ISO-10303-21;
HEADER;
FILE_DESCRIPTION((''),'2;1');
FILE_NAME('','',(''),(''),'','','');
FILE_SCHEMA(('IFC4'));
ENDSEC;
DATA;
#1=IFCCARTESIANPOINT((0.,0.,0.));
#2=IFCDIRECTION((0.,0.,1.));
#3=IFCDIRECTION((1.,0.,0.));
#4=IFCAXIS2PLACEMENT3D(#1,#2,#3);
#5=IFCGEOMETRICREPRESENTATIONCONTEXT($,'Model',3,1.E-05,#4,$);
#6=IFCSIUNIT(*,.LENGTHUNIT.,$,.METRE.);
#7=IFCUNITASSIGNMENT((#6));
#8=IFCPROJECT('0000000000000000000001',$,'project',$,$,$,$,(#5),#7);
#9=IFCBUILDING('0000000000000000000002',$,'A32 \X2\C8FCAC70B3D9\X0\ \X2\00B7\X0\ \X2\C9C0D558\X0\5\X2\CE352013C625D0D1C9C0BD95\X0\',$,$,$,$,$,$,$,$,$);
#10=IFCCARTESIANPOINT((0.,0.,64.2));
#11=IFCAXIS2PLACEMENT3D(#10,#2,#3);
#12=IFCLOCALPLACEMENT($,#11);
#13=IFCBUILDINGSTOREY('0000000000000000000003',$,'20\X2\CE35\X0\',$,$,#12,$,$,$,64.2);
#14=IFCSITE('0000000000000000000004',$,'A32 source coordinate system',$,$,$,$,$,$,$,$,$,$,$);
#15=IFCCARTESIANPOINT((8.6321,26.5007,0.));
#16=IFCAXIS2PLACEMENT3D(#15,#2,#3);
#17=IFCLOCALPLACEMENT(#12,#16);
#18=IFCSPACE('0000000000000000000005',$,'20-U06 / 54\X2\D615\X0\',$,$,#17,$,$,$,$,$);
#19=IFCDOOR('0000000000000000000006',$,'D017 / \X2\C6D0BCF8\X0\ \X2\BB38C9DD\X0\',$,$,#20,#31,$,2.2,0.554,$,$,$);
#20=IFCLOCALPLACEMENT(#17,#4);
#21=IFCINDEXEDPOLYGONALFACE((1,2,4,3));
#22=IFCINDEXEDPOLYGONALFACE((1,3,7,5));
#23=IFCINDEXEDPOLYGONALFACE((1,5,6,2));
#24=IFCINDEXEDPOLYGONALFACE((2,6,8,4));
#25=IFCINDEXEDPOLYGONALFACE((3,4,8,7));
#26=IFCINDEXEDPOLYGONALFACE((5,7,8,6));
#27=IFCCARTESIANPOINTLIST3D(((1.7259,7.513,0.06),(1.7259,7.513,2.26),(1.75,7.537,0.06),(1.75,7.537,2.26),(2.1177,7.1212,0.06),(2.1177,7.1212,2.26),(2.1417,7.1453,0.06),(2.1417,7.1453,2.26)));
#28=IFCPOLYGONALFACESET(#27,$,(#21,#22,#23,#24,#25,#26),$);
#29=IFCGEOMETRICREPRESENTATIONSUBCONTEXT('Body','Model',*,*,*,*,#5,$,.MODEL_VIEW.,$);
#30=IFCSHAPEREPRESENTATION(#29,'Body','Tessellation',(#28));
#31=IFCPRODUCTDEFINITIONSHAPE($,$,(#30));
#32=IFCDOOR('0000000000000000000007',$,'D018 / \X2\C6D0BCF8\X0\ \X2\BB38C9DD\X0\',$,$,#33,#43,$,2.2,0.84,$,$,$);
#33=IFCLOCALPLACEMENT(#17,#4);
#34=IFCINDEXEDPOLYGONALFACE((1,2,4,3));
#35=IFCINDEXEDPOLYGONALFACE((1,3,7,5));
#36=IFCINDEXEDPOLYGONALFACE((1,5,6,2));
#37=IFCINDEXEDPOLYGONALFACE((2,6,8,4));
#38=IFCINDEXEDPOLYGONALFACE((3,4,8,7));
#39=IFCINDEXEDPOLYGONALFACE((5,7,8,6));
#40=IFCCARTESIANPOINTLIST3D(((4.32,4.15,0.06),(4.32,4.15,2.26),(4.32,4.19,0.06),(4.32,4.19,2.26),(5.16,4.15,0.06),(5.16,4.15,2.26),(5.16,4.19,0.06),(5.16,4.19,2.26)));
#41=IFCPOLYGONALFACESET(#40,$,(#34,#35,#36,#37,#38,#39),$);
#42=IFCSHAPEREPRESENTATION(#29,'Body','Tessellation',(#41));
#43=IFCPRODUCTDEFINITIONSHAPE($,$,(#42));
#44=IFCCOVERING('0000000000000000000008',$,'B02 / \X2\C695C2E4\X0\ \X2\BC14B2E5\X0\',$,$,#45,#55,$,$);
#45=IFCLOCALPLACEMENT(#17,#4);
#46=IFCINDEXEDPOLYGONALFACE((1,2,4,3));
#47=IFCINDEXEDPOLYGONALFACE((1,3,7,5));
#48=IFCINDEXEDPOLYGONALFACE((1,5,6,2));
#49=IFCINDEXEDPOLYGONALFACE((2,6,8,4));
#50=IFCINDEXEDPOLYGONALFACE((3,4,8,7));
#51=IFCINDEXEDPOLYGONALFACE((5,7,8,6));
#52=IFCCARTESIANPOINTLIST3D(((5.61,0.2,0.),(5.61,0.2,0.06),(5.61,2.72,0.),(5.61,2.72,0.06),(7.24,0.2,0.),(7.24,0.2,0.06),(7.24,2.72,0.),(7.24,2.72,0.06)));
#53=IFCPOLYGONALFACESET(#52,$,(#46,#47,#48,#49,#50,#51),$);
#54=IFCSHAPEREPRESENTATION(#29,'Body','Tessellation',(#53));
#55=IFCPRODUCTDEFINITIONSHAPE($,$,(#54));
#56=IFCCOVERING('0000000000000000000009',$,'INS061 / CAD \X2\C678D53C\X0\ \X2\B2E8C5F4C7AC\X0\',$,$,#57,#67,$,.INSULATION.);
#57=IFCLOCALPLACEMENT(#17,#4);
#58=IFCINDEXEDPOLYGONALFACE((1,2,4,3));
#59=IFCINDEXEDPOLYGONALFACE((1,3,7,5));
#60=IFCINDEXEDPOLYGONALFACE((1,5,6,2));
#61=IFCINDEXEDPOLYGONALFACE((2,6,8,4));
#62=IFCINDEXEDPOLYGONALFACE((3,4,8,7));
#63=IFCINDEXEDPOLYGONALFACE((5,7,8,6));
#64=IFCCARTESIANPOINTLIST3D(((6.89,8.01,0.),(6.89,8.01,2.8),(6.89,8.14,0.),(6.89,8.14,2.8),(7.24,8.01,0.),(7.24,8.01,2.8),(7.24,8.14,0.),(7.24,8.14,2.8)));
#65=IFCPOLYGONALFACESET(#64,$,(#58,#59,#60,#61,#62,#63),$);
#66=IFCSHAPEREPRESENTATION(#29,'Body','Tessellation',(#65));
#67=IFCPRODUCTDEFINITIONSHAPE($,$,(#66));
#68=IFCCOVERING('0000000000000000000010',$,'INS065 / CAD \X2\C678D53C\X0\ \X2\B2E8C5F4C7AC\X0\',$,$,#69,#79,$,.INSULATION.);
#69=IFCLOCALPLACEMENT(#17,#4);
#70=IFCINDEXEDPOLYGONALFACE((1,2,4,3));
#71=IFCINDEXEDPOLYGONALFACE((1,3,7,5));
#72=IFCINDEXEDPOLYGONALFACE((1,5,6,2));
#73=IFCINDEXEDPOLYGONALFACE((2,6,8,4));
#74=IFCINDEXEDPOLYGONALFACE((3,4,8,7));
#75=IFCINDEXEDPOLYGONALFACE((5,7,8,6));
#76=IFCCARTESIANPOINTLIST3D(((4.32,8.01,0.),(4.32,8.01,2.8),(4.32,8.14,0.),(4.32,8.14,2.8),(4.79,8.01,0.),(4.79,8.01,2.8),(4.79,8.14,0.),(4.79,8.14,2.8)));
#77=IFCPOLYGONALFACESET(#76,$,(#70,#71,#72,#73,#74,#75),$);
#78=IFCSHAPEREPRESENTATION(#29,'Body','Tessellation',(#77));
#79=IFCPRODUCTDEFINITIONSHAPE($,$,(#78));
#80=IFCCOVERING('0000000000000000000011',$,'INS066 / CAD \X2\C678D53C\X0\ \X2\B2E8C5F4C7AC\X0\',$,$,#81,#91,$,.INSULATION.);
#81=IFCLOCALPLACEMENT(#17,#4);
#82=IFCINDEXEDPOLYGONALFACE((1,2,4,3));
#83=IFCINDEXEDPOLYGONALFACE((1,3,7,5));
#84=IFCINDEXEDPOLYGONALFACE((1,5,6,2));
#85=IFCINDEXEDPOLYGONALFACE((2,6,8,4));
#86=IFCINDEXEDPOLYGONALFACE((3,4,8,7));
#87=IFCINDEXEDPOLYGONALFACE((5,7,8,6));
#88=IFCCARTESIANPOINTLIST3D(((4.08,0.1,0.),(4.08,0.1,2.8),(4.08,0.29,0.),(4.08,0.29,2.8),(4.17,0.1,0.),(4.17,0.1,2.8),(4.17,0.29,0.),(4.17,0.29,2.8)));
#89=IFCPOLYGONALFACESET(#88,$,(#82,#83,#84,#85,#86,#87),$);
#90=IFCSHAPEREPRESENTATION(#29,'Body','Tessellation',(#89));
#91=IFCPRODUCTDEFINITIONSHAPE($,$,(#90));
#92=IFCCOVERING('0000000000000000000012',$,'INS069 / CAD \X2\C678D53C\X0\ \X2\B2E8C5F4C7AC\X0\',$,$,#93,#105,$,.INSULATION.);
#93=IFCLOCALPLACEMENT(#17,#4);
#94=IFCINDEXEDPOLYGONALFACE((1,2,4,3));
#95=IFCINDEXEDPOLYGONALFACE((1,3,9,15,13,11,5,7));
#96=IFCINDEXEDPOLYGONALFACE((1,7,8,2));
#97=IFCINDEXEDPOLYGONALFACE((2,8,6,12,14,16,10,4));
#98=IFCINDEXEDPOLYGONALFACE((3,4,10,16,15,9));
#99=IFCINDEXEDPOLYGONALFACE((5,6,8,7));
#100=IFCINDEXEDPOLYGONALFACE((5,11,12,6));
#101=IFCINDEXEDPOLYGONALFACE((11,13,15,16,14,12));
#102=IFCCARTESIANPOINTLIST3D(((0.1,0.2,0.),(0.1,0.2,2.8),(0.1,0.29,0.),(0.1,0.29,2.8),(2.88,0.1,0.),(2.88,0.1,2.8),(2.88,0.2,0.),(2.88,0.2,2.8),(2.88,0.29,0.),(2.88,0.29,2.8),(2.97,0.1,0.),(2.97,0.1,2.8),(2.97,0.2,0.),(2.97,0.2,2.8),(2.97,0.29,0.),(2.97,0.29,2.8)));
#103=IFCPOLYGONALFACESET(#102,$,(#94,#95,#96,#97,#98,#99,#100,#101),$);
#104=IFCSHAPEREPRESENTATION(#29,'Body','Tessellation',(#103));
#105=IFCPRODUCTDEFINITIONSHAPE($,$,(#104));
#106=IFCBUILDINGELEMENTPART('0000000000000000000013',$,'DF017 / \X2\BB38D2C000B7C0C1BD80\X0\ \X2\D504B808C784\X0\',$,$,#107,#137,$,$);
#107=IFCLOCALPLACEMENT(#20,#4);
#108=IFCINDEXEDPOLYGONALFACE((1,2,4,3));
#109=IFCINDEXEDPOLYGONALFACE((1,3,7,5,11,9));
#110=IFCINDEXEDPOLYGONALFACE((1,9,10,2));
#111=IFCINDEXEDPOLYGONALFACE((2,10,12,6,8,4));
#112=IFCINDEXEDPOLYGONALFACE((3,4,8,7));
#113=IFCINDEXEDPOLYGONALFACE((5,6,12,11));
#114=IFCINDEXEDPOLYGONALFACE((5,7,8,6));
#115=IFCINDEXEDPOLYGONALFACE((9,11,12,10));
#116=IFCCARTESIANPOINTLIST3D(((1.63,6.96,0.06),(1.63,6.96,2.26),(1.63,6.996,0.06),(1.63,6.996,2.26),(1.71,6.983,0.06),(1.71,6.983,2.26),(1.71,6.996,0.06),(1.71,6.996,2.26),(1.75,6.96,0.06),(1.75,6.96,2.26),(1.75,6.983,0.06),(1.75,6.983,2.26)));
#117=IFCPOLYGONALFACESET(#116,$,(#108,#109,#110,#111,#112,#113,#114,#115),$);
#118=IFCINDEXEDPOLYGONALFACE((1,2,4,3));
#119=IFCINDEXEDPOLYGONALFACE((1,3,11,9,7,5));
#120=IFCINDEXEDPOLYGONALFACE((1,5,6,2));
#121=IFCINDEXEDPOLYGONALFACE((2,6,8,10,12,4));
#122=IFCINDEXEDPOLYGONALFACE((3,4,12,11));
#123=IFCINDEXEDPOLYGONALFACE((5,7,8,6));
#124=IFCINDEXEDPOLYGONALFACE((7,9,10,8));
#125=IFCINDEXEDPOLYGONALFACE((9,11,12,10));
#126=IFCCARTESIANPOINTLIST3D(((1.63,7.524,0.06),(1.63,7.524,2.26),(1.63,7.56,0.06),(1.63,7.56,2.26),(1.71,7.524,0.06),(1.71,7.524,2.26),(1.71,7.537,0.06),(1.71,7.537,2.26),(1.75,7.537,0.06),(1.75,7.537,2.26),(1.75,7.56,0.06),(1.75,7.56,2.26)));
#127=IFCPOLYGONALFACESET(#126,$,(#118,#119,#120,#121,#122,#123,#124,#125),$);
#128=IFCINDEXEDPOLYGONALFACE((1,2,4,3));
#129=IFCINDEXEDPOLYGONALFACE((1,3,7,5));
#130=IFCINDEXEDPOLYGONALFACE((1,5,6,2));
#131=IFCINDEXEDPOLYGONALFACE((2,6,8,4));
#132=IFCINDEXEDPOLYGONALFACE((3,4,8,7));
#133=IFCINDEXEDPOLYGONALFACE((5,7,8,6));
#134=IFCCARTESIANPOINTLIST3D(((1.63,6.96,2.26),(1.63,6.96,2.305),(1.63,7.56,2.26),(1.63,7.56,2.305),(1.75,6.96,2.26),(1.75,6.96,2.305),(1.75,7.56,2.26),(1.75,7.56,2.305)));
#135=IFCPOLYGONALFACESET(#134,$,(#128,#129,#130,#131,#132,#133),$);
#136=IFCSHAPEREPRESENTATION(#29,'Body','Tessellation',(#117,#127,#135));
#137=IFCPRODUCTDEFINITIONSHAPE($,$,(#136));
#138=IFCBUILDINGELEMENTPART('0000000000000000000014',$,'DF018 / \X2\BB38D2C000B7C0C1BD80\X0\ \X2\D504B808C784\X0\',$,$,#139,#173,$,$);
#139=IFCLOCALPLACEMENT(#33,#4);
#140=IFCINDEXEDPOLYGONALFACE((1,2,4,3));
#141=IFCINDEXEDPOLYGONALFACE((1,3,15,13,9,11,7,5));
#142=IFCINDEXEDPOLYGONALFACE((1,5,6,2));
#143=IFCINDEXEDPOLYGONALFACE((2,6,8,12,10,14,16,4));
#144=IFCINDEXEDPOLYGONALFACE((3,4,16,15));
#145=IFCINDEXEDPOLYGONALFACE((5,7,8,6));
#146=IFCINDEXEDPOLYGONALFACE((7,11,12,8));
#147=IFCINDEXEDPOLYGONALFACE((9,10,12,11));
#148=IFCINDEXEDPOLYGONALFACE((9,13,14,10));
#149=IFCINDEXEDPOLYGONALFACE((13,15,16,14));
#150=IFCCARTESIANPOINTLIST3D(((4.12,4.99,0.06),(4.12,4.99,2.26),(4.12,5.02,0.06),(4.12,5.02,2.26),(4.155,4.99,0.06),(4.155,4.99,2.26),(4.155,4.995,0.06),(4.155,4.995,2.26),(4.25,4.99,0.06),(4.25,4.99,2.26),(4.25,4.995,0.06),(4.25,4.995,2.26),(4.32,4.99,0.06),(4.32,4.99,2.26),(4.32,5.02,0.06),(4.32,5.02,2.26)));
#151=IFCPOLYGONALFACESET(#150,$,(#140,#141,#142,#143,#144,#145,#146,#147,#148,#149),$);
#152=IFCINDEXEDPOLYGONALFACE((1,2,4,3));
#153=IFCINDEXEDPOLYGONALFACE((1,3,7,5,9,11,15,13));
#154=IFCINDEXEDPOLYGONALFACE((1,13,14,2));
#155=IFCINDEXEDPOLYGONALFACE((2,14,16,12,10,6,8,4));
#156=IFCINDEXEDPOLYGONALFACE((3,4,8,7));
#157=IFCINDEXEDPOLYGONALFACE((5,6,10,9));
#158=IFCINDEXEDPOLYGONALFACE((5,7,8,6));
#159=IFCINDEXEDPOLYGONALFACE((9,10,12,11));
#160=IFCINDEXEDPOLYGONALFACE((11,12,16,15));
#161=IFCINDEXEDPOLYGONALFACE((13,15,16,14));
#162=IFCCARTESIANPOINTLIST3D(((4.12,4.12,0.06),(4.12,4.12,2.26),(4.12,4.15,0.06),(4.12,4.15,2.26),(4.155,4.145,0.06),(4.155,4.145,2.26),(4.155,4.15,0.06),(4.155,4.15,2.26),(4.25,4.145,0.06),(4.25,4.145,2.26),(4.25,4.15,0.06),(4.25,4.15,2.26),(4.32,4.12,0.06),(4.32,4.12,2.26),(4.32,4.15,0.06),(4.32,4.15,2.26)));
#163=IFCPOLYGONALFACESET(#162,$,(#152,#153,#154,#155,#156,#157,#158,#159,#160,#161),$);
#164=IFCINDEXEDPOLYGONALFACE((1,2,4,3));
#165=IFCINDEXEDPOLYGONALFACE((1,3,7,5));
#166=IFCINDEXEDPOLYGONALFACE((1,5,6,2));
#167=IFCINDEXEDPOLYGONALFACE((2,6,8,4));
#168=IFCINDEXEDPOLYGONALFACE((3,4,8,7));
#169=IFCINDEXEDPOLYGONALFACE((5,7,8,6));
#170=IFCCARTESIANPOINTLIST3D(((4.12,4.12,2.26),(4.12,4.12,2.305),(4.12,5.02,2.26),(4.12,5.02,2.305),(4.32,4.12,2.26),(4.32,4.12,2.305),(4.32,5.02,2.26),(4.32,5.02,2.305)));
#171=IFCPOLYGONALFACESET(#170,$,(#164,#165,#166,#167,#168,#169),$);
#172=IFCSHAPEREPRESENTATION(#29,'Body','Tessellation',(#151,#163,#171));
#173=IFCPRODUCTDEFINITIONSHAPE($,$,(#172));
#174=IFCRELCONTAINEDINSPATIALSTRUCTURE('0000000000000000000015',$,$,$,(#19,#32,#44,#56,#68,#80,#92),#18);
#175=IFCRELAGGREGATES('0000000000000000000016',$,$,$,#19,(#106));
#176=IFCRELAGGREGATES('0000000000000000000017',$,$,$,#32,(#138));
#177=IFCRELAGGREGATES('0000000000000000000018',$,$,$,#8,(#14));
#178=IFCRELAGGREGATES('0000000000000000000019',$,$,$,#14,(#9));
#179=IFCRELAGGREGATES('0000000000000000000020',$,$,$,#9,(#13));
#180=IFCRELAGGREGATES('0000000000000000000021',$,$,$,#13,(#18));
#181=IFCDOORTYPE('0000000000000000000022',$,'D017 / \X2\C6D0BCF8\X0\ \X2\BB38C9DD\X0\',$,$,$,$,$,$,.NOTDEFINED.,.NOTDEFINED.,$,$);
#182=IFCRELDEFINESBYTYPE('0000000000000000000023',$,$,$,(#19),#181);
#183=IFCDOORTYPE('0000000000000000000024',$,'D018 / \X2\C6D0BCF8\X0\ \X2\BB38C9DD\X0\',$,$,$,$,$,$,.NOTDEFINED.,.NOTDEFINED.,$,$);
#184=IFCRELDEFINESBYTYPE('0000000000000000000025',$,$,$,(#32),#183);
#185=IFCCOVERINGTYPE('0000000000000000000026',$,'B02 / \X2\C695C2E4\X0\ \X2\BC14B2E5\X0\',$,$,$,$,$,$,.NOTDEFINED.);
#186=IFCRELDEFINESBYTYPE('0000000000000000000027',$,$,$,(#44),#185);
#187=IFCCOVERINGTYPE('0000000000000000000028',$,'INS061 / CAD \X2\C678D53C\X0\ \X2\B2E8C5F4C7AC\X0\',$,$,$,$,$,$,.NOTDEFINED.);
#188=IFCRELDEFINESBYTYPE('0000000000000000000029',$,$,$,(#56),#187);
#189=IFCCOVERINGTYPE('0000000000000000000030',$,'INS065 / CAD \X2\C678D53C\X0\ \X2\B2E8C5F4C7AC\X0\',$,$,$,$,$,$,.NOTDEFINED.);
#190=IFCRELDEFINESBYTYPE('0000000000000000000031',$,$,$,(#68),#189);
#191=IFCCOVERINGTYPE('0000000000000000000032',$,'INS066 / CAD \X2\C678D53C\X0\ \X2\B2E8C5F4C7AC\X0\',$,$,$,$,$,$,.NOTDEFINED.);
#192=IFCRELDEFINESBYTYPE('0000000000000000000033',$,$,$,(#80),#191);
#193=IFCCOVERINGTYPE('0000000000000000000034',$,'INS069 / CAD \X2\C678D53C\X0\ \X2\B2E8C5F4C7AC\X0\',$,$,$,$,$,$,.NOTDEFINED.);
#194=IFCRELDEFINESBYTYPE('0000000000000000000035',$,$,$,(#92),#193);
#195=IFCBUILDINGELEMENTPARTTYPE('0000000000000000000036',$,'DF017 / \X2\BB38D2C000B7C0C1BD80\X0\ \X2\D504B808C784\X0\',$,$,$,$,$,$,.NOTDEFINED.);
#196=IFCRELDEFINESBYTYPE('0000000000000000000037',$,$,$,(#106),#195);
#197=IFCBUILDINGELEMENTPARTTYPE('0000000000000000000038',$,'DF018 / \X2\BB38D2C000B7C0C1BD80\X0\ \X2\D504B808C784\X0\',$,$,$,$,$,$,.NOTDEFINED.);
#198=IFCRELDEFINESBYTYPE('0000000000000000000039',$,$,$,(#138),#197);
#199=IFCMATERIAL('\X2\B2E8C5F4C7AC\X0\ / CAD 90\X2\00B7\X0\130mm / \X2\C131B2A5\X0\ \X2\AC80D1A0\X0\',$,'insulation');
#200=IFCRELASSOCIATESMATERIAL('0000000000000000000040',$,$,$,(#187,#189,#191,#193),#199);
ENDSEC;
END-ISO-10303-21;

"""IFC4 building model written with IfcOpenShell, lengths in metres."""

from ifc_helpers import new_model, si_unit, frame, origin, origin_with_axes, place, context, subcontext, project, spatial, polyline, outline, extrude, source, transform, mapped, material, type_object, type_shapes, element, aggregate, save


model = new_model("IFC4")

# Units and contexts
model_context = context("Model", 3, precision=1e-05, world=origin_with_axes())
body_context = subcontext(model_context, "Body", "Model", "MODEL_VIEW")
ifc_project = project(units=[si_unit("LENGTHUNIT", "METRE")], contexts=[model_context])

# Site, building, storey, space
storey_placement = place(None, frame((0.0, 0.0, 64.2), z_axis=(0.0, 0.0, 1.0), x_axis=(1.0, 0.0, 0.0)))
space_1_placement = place(storey_placement, frame((8.6321, 26.5007, 0.0), z_axis=(0.0, 0.0, 1.0), x_axis=(1.0, 0.0, 0.0)))
site = spatial("IfcSite", under=ifc_project, Name="A32 source coordinate system")
building = spatial("IfcBuilding", under=site, Name="A32 주거동 · 지하5층–옥탑지붕")
storey = spatial("IfcBuildingStorey", under=building, at=storey_placement, Name="20층", Elevation=64.2)
space_1 = spatial("IfcSpace", under=storey, at=space_1_placement, Name="20-U06 / 54형")

# Doors
door_type_1 = type_object("IfcDoorType", Name="D017 / 원본 문짝", OperationType="NOTDEFINED", PredefinedType="NOTDEFINED")
shared_shape_1 = source(origin(), body_context, "Body", "SweptSolid", [
    extrude(outline(polyline([(1.75, 7.537), (2.1417, 7.1453), (2.1177, 7.1212), (1.7259, 7.513), (1.75, 7.537)])), frame((0.0, 0.0, 0.06)), (0.0, 0.0, 1.0), 2.2),
])
type_shapes(door_type_1, [shared_shape_1])
door_1_placement = place(space_1_placement, origin_with_axes())
door_1 = element("IfcDoor", 1, at=door_1_placement, inside=space_1, type_object=door_type_1, Name="D017 / 원본 문짝", OverallHeight=2.2, OverallWidth=0.554, context=body_context, shape_type="MappedRepresentation", body=[
    mapped(shared_shape_1, transform((0.0, 0.0, 0.0), scale=1.0)),
])
door_type_2 = type_object("IfcDoorType", Name="D018 / 원본 문짝", OperationType="NOTDEFINED", PredefinedType="NOTDEFINED")
shared_shape_2 = source(origin(), body_context, "Body", "SweptSolid", [
    extrude(outline(polyline([(5.16, 4.19), (5.16, 4.15), (4.32, 4.15), (4.32, 4.19), (5.16, 4.19)])), frame((0.0, 0.0, 0.06)), (0.0, 0.0, 1.0), 2.2),
])
type_shapes(door_type_2, [shared_shape_2])
door_2_placement = place(space_1_placement, origin_with_axes())
door_2 = element("IfcDoor", 2, at=door_2_placement, inside=space_1, type_object=door_type_2, Name="D018 / 원본 문짝", OverallHeight=2.2, OverallWidth=0.84, context=body_context, shape_type="MappedRepresentation", body=[
    mapped(shared_shape_2, transform((0.0, 0.0, 0.0), scale=1.0)),
])

# Coverings
covering_type_1 = type_object("IfcCoveringType", Name="B02 / 욕실 바닥", PredefinedType="NOTDEFINED")
shared_shape_3 = source(origin(), body_context, "Body", "SweptSolid", [
    extrude(outline(polyline([(5.61, 2.72), (7.24, 2.72), (7.24, 0.2), (5.61, 0.2), (5.61, 2.72)])), origin(), (0.0, 0.0, 1.0), 0.06),
])
type_shapes(covering_type_1, [shared_shape_3])
covering_1_placement = place(space_1_placement, origin_with_axes())
element("IfcCovering", 3, at=covering_1_placement, inside=space_1, type_object=covering_type_1, Name="B02 / 욕실 바닥", context=body_context, shape_type="MappedRepresentation", body=[
    mapped(shared_shape_3, transform((0.0, 0.0, 0.0), scale=1.0)),
])
ifc_material = material(Name="단열재 / CAD 90·130mm / 성능 검토", Category="insulation")
covering_type_2 = type_object("IfcCoveringType", Name="INS061 / CAD 외피 단열재", PredefinedType="NOTDEFINED", material=ifc_material)
shared_shape_4 = source(origin(), body_context, "Body", "SweptSolid", [
    extrude(outline(polyline([(6.89, 8.01), (6.89, 8.14), (7.24, 8.14), (7.24, 8.01), (6.89, 8.01)])), origin(), (0.0, 0.0, 1.0), 2.8),
])
type_shapes(covering_type_2, [shared_shape_4])
covering_2_placement = place(space_1_placement, origin_with_axes())
element("IfcCovering", 4, at=covering_2_placement, inside=space_1, type_object=covering_type_2, Name="INS061 / CAD 외피 단열재", PredefinedType="INSULATION", context=body_context, shape_type="MappedRepresentation", body=[
    mapped(shared_shape_4, transform((0.0, 0.0, 0.0), scale=1.0)),
])
covering_type_3 = type_object("IfcCoveringType", Name="INS065 / CAD 외피 단열재", PredefinedType="NOTDEFINED", material=ifc_material)
shared_shape_5 = source(origin(), body_context, "Body", "SweptSolid", [
    extrude(outline(polyline([(4.32, 8.01), (4.32, 8.14), (4.79, 8.14), (4.79, 8.01), (4.32, 8.01)])), origin(), (0.0, 0.0, 1.0), 2.8),
])
type_shapes(covering_type_3, [shared_shape_5])
covering_3_placement = place(space_1_placement, origin_with_axes())
element("IfcCovering", 5, at=covering_3_placement, inside=space_1, type_object=covering_type_3, Name="INS065 / CAD 외피 단열재", PredefinedType="INSULATION", context=body_context, shape_type="MappedRepresentation", body=[
    mapped(shared_shape_5, transform((0.0, 0.0, 0.0), scale=1.0)),
])
covering_type_4 = type_object("IfcCoveringType", Name="INS066 / CAD 외피 단열재", PredefinedType="NOTDEFINED", material=ifc_material)
shared_shape_6 = source(origin(), body_context, "Body", "SweptSolid", [
    extrude(outline(polyline([(4.08, 0.29), (4.17, 0.29), (4.17, 0.1), (4.08, 0.1), (4.08, 0.29)])), origin(), (0.0, 0.0, 1.0), 2.8),
])
type_shapes(covering_type_4, [shared_shape_6])
covering_4_placement = place(space_1_placement, origin_with_axes())
element("IfcCovering", 6, at=covering_4_placement, inside=space_1, type_object=covering_type_4, Name="INS066 / CAD 외피 단열재", PredefinedType="INSULATION", context=body_context, shape_type="MappedRepresentation", body=[
    mapped(shared_shape_6, transform((0.0, 0.0, 0.0), scale=1.0)),
])
covering_type_5 = type_object("IfcCoveringType", Name="INS069 / CAD 외피 단열재", PredefinedType="NOTDEFINED", material=ifc_material)
shared_shape_7 = source(origin(), body_context, "Body", "SweptSolid", [
    extrude(outline(polyline([(2.97, 0.1), (2.88, 0.1), (2.88, 0.2), (0.1, 0.2), (0.1, 0.29), (2.88, 0.29), (2.97, 0.29), (2.97, 0.2), (2.97, 0.1)])), origin(), (0.0, 0.0, 1.0), 2.8),
])
type_shapes(covering_type_5, [shared_shape_7])
covering_5_placement = place(space_1_placement, origin_with_axes())
element("IfcCovering", 7, at=covering_5_placement, inside=space_1, type_object=covering_type_5, Name="INS069 / CAD 외피 단열재", PredefinedType="INSULATION", context=body_context, shape_type="MappedRepresentation", body=[
    mapped(shared_shape_7, transform((0.0, 0.0, 0.0), scale=1.0)),
])

# Building element parts
building_element_part_type_1 = type_object("IfcBuildingElementPartType", Name="DF017 / 문틀·상부 프레임", PredefinedType="NOTDEFINED")
shared_shape_8 = source(origin(), body_context, "Body", "SweptSolid", [
    extrude(outline(polyline([(1.63, 6.996), (1.71, 6.996), (1.71, 6.983), (1.75, 6.983), (1.75, 6.96), (1.63, 6.96), (1.63, 6.996)])), frame((0.0, 0.0, 0.06)), (0.0, 0.0, 1.0), 2.2),
    extrude(outline(polyline([(1.75, 7.56), (1.75, 7.537), (1.71, 7.537), (1.71, 7.524), (1.63, 7.524), (1.63, 7.56), (1.75, 7.56)])), frame((0.0, 0.0, 0.06)), (0.0, 0.0, 1.0), 2.2),
    extrude(outline(polyline([(1.63, 6.96), (1.63, 7.56), (1.75, 7.56), (1.75, 6.96), (1.63, 6.96)])), frame((0.0, 0.0, 2.26)), (0.0, 0.0, 1.0), 0.045),
])
type_shapes(building_element_part_type_1, [shared_shape_8])
building_element_part_1_placement = place(door_1_placement, origin_with_axes())
building_element_part_1 = element("IfcBuildingElementPart", 8, at=building_element_part_1_placement, type_object=building_element_part_type_1, Name="DF017 / 문틀·상부 프레임", context=body_context, shape_type="MappedRepresentation", body=[
    mapped(shared_shape_8, transform((0.0, 0.0, 0.0), scale=1.0)),
])
aggregate(door_1, [building_element_part_1])
building_element_part_type_2 = type_object("IfcBuildingElementPartType", Name="DF018 / 문틀·상부 프레임", PredefinedType="NOTDEFINED")
shared_shape_9 = source(origin(), body_context, "Body", "SweptSolid", [
    extrude(outline(polyline([(4.32, 4.99), (4.25, 4.99), (4.25, 4.995), (4.155, 4.995), (4.155, 4.99), (4.12, 4.99), (4.12, 5.02), (4.32, 5.02), (4.32, 4.99)])), frame((0.0, 0.0, 0.06)), (0.0, 0.0, 1.0), 2.2),
    extrude(outline(polyline([(4.12, 4.12), (4.12, 4.15), (4.155, 4.15), (4.155, 4.145), (4.25, 4.145), (4.25, 4.15), (4.32, 4.15), (4.32, 4.12), (4.12, 4.12)])), frame((0.0, 0.0, 0.06)), (0.0, 0.0, 1.0), 2.2),
    extrude(outline(polyline([(4.12, 4.12), (4.12, 5.02), (4.32, 5.02), (4.32, 4.12), (4.12, 4.12)])), frame((0.0, 0.0, 2.26)), (0.0, 0.0, 1.0), 0.045),
])
type_shapes(building_element_part_type_2, [shared_shape_9])
building_element_part_2_placement = place(door_2_placement, origin_with_axes())
building_element_part_2 = element("IfcBuildingElementPart", 9, at=building_element_part_2_placement, type_object=building_element_part_type_2, Name="DF018 / 문틀·상부 프레임", context=body_context, shape_type="MappedRepresentation", body=[
    mapped(shared_shape_9, transform((0.0, 0.0, 0.0), scale=1.0)),
])
aggregate(door_2, [building_element_part_2])

save(model, "model.ifc")
